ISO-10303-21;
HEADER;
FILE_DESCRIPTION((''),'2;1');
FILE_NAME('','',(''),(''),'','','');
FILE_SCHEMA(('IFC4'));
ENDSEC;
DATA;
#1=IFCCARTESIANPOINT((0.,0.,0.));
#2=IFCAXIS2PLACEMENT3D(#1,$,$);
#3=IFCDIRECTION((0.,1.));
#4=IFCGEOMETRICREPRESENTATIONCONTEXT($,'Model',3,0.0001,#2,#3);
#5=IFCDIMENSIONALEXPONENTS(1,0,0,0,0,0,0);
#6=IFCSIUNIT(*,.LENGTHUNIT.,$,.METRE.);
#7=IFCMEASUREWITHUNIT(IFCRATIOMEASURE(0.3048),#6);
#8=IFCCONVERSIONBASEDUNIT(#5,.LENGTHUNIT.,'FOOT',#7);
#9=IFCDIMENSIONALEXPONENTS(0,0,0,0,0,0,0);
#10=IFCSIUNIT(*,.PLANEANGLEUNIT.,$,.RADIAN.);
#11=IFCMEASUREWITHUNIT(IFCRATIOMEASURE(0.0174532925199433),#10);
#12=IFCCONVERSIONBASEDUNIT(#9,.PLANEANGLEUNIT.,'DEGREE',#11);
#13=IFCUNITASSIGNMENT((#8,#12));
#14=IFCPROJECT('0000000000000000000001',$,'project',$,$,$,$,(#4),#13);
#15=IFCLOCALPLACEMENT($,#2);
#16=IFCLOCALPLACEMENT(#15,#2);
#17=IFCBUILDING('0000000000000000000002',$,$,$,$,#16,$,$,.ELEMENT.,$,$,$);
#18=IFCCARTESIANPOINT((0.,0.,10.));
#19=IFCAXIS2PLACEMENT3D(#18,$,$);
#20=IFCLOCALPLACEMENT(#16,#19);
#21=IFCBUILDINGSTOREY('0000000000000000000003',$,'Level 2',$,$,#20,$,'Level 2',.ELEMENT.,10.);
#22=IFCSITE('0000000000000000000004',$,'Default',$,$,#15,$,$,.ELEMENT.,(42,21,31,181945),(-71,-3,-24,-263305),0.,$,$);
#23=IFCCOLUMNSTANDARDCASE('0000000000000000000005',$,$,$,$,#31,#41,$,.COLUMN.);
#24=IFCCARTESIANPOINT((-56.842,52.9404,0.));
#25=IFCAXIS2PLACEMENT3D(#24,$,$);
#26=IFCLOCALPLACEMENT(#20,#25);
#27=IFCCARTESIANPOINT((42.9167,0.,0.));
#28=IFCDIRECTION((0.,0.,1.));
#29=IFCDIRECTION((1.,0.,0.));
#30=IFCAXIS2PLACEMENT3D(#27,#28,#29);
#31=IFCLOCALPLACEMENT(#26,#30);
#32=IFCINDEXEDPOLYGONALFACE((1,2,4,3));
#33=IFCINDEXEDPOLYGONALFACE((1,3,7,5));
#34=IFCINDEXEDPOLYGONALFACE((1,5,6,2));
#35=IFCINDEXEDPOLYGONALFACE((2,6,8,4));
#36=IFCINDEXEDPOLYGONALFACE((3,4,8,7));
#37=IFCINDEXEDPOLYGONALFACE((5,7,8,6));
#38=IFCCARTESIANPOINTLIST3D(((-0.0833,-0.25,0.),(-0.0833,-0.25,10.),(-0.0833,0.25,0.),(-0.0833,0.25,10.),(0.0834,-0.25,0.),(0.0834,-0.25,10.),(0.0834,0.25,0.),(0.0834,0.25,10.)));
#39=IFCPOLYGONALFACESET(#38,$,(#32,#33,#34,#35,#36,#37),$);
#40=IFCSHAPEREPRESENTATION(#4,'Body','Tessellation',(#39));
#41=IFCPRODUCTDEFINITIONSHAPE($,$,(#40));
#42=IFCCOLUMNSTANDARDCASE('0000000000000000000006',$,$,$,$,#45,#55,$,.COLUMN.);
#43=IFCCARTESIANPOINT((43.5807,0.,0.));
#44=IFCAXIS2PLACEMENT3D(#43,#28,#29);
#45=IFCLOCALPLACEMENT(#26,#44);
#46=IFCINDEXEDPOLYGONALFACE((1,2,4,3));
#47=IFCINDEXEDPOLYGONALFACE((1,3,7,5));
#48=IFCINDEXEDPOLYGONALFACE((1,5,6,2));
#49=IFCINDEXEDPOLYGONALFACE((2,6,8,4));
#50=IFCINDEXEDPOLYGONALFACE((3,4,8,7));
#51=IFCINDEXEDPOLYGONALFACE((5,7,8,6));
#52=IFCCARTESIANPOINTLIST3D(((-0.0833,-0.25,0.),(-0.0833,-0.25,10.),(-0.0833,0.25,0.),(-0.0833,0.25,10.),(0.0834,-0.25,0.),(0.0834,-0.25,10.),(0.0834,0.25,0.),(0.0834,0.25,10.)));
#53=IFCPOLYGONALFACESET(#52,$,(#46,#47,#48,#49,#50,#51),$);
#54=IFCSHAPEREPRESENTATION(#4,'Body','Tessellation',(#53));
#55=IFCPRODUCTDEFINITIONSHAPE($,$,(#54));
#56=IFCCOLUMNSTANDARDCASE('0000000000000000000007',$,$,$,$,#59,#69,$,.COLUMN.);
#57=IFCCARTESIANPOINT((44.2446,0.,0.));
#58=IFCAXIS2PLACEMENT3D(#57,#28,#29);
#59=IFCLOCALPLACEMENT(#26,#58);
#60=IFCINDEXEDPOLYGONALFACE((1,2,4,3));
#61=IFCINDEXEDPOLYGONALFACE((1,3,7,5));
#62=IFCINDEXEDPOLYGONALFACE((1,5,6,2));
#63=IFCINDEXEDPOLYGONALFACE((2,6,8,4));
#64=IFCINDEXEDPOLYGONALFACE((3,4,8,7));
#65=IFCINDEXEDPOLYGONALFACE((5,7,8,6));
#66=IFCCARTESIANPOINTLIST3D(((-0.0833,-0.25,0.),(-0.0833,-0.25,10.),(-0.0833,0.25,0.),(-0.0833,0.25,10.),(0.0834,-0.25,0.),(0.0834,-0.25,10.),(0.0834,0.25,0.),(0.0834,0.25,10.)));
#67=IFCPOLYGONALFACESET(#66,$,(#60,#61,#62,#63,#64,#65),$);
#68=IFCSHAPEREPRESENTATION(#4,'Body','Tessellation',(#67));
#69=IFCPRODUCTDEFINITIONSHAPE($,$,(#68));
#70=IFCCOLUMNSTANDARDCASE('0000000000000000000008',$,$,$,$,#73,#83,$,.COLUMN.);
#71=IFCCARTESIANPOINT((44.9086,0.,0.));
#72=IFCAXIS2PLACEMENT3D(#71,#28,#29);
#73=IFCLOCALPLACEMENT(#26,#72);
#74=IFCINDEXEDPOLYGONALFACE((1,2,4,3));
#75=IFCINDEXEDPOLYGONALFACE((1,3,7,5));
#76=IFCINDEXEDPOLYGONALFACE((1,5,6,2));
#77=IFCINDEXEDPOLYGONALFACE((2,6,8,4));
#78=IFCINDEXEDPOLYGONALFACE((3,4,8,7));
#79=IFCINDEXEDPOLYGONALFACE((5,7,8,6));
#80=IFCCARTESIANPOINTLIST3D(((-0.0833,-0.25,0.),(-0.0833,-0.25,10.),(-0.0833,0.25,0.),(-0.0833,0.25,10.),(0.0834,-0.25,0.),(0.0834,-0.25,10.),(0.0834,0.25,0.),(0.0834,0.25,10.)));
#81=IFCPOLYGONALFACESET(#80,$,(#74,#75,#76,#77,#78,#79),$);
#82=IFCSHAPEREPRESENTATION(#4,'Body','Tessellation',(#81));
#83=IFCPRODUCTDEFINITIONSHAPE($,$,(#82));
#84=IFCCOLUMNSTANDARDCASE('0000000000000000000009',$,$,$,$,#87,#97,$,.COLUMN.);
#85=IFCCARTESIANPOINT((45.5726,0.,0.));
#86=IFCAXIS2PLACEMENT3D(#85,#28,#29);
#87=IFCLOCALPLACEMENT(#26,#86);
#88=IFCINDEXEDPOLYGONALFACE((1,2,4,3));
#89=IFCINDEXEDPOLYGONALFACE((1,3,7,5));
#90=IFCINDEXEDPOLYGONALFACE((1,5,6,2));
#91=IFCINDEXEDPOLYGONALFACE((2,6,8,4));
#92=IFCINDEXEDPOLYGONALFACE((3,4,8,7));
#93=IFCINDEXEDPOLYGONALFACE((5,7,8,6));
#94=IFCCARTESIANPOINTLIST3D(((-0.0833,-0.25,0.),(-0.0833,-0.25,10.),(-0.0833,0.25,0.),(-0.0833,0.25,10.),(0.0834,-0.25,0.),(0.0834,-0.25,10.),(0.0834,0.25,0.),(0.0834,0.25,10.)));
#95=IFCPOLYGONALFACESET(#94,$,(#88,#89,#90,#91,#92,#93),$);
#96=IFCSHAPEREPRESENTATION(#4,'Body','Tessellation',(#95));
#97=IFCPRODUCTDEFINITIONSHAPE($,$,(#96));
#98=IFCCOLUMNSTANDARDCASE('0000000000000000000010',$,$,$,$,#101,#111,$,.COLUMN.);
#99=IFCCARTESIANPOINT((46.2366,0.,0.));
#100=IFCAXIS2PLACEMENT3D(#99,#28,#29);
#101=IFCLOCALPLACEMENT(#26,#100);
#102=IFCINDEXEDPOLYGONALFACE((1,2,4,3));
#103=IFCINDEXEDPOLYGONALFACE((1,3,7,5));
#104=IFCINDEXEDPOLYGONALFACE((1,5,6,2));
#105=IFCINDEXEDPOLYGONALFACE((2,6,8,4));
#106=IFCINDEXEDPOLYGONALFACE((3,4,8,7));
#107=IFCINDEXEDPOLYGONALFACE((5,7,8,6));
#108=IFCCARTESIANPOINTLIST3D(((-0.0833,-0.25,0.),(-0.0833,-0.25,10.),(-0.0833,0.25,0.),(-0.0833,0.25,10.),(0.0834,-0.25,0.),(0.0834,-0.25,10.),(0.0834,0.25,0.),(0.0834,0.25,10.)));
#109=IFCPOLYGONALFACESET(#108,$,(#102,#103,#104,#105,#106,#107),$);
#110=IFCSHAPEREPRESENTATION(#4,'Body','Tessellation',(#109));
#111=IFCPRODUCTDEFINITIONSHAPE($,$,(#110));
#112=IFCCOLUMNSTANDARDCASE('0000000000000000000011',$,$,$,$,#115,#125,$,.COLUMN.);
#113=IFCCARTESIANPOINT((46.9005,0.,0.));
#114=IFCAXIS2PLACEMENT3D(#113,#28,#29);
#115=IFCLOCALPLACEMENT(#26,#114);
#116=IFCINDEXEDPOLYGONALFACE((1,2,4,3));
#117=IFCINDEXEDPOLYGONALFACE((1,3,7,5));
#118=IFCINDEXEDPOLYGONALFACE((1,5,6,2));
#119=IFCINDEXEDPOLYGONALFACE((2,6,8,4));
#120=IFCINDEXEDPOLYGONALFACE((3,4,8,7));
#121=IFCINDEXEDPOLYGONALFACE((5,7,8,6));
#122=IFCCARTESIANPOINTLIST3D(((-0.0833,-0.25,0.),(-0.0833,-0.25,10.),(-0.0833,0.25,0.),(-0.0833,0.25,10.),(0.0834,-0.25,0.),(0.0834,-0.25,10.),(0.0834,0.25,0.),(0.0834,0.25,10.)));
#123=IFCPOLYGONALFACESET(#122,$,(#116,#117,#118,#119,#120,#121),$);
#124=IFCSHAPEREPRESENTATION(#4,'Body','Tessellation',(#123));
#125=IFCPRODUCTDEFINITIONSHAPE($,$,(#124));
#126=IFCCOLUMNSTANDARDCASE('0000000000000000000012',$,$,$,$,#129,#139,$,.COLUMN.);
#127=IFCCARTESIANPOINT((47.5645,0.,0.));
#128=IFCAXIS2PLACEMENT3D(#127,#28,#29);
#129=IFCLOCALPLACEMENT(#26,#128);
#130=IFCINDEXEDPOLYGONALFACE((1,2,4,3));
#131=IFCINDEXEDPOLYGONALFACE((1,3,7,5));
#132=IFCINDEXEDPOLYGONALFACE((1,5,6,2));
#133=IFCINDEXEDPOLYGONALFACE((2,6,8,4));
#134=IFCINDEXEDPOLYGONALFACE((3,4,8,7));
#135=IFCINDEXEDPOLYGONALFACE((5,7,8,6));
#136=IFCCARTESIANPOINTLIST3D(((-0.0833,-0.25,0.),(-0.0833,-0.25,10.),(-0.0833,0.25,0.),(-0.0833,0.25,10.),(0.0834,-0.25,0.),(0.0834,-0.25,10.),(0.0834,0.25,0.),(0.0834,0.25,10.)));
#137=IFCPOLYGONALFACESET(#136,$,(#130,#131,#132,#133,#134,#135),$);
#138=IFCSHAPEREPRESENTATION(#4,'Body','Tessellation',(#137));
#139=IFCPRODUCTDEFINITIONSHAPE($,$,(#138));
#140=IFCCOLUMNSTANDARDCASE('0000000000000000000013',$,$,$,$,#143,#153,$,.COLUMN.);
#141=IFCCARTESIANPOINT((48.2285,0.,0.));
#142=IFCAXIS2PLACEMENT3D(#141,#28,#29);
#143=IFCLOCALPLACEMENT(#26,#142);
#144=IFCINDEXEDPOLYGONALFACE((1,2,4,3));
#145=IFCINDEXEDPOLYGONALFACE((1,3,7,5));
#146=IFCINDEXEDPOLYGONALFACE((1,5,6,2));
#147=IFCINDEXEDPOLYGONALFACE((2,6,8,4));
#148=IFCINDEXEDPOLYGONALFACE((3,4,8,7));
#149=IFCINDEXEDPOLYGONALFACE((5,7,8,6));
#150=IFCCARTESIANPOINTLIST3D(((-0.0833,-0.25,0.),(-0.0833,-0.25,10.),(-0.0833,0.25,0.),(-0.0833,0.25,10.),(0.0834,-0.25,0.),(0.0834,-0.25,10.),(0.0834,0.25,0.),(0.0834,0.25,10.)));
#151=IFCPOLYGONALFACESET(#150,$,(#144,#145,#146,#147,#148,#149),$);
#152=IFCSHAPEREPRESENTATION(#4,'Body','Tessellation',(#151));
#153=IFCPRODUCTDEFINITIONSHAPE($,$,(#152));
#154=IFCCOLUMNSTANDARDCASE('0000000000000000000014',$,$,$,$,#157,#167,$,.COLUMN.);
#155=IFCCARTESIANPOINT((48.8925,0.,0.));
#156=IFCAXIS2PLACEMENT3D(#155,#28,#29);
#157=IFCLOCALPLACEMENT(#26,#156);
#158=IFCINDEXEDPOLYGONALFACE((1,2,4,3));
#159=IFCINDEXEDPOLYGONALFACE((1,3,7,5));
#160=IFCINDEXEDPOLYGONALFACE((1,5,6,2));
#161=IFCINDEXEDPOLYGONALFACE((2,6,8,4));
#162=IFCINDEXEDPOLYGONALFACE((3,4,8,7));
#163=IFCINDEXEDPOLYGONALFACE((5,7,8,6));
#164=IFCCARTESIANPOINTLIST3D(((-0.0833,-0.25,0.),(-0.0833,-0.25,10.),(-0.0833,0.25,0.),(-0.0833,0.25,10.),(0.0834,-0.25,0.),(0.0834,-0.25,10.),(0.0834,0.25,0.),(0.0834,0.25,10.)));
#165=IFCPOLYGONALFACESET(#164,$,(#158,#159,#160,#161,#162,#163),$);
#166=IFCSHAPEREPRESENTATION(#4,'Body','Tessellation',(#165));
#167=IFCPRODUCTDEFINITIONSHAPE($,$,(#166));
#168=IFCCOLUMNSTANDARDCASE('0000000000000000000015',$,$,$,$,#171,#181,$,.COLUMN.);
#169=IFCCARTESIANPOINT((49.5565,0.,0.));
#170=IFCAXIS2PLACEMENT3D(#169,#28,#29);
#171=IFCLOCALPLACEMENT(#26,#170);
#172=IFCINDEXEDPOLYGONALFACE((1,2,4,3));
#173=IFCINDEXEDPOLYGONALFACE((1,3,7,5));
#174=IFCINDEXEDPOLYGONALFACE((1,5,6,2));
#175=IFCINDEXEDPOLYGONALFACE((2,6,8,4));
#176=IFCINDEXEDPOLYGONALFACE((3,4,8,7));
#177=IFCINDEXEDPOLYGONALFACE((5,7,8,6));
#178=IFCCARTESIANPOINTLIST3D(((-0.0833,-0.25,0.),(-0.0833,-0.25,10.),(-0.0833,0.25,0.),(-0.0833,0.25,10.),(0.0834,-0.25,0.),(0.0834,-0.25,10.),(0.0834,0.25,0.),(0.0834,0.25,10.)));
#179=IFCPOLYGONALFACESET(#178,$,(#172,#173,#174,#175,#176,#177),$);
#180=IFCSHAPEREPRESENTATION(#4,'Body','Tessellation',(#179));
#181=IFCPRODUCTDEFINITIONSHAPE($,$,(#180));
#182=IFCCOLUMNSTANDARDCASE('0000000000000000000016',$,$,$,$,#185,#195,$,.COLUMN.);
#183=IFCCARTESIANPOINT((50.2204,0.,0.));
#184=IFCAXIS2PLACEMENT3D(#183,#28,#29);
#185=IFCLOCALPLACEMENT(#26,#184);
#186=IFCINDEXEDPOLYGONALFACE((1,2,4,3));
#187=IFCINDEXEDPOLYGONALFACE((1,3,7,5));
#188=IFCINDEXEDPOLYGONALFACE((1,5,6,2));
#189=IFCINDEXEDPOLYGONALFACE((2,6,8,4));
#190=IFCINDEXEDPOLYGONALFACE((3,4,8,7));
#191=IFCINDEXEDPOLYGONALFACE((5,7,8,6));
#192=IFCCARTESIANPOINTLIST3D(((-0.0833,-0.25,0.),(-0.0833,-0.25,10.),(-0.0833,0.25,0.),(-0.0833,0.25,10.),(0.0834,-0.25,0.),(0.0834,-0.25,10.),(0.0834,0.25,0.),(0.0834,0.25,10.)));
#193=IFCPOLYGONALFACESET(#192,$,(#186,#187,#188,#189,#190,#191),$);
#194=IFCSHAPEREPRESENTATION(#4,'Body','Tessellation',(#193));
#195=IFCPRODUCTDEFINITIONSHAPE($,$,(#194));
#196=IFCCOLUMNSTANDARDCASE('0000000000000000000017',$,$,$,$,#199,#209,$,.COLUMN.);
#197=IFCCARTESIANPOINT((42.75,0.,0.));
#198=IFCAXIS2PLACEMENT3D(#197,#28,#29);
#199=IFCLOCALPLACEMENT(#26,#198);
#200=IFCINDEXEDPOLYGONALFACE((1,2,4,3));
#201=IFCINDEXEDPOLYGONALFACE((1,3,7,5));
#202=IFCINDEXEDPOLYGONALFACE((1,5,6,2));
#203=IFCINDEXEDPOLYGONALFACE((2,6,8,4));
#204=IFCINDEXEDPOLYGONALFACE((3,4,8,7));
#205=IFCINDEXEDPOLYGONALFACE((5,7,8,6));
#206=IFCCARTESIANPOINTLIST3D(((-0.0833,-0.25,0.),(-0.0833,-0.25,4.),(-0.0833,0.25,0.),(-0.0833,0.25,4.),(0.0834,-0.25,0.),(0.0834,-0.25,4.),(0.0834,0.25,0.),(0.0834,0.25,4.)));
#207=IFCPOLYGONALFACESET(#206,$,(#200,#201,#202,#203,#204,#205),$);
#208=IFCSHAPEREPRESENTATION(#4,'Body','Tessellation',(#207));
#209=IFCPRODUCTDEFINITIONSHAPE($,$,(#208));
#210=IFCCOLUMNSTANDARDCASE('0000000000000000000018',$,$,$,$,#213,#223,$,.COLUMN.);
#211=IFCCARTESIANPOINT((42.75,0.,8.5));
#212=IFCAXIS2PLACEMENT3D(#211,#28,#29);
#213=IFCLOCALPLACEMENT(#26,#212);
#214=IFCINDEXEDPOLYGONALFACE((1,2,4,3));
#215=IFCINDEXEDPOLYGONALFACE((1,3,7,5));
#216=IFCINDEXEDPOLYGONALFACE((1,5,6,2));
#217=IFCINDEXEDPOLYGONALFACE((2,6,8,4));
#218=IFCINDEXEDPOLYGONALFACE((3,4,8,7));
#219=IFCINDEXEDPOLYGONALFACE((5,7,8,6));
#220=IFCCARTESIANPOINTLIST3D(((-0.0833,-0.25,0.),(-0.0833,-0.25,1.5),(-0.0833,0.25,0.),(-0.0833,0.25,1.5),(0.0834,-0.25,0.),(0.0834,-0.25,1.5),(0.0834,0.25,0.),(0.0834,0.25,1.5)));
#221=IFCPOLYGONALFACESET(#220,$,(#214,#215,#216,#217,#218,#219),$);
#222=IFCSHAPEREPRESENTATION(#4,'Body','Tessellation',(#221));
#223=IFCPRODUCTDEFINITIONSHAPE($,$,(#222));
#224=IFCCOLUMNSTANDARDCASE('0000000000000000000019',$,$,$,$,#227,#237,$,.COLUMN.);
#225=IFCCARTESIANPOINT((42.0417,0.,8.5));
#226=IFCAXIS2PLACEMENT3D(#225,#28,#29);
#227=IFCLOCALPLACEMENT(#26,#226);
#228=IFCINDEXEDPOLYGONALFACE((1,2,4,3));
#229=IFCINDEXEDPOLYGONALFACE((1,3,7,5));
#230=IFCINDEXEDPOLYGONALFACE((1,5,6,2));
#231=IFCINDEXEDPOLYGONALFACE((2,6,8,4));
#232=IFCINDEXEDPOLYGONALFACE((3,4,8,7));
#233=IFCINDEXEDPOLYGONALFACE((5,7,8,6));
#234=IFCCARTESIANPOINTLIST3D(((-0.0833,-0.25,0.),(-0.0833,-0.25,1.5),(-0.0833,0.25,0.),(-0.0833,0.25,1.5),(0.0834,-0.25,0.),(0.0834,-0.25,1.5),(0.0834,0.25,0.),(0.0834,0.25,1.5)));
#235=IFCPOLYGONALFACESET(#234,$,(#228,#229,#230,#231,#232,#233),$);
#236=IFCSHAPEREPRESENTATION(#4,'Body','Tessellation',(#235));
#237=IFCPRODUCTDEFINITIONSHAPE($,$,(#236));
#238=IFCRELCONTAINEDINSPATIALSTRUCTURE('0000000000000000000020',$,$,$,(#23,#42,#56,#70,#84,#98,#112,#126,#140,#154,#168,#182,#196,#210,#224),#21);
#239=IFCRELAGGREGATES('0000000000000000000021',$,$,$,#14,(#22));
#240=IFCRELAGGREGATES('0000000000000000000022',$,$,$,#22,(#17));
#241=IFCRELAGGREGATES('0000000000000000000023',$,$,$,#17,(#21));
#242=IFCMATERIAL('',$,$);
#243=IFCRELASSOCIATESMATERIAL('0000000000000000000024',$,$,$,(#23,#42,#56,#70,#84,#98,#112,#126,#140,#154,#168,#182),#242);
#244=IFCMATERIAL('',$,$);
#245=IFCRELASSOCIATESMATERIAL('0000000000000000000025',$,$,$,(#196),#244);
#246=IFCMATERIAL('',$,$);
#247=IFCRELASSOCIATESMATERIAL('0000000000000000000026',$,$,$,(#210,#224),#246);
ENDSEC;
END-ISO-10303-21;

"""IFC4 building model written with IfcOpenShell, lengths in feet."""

from ifc_helpers import new_model, entity, si_unit, converted_unit, direction, frame, origin, place, context, project, spatial, rectangle, extrude, material, element, save


model = new_model("IFC4")

# Units and contexts
model_context = context("Model", 3, precision=0.0001, world=origin(), true_north=direction((0.0, 1.0)))
ifc_project = project(units=[converted_unit("LENGTHUNIT", "FOOT", entity("IfcRatioMeasure", 0.3048), si_unit("LENGTHUNIT", "METRE"), dimensions=[1, 0, 0, 0, 0, 0, 0]), converted_unit("PLANEANGLEUNIT", "DEGREE", entity("IfcRatioMeasure", 0.0174532925199433), si_unit("PLANEANGLEUNIT", "RADIAN"), dimensions=[0, 0, 0, 0, 0, 0, 0])], contexts=[model_context])

# Site, building, storey
site_placement = place(None, origin())
site = spatial("IfcSite", under=ifc_project, at=site_placement, Name="Default", CompositionType="ELEMENT", RefLatitude=(42, 21, 31, 181945), RefLongitude=(-71, -3, -24, -263305), RefElevation=0.0)
building_placement = place(site_placement, origin())
building = spatial("IfcBuilding", under=site, at=building_placement, CompositionType="ELEMENT")
storey_placement = place(building_placement, frame((0.0, 0.0, 10.0)))
storey = spatial("IfcBuildingStorey", under=building, at=storey_placement, Name="Level 2", LongName="Level 2", CompositionType="ELEMENT", Elevation=10.0)

# Columns
ifc_material_1 = material(Name="")
placement = place(storey_placement, frame((-56.842, 52.9404, 0.0)))
for number, where, z_axis, x_axis in (
    (1, (42.9167, 0.0, 0.0), (0.0, 0.0, 1.0), (1.0, 0.0, 0.0)),
    (2, (43.5807, 0.0, 0.0), (0.0, 0.0, 1.0), (1.0, 0.0, 0.0)),
    (3, (44.2446, 0.0, 0.0), (0.0, 0.0, 1.0), (1.0, 0.0, 0.0)),
    (4, (44.9086, 0.0, 0.0), (0.0, 0.0, 1.0), (1.0, 0.0, 0.0)),
    (5, (45.5726, 0.0, 0.0), (0.0, 0.0, 1.0), (1.0, 0.0, 0.0)),
    (6, (46.2366, 0.0, 0.0), (0.0, 0.0, 1.0), (1.0, 0.0, 0.0)),
    (7, (46.9005, 0.0, 0.0), (0.0, 0.0, 1.0), (1.0, 0.0, 0.0)),
    (8, (47.5645, 0.0, 0.0), (0.0, 0.0, 1.0), (1.0, 0.0, 0.0)),
    (9, (48.2285, 0.0, 0.0), (0.0, 0.0, 1.0), (1.0, 0.0, 0.0)),
    (10, (48.8925, 0.0, 0.0), (0.0, 0.0, 1.0), (1.0, 0.0, 0.0)),
    (11, (49.5565, 0.0, 0.0), (0.0, 0.0, 1.0), (1.0, 0.0, 0.0)),
    (12, (50.2204, 0.0, 0.0), (0.0, 0.0, 1.0), (1.0, 0.0, 0.0)),
):
    element("IfcColumnStandardCase", number, at=place(placement, frame(where, z_axis=z_axis, x_axis=x_axis)), inside=storey, material=ifc_material_1, PredefinedType="COLUMN", context=model_context, shape_type="SweptSolid", body=[
        extrude(rectangle(XDim=0.1667, YDim=0.5), origin(), (0.0, 0.0, 1.0), 10.0),
    ])
ifc_material_2 = material(Name="")
for number, where, z_axis, x_axis in (
    (13, (42.75, 0.0, 0.0), (0.0, 0.0, 1.0), (1.0, 0.0, 0.0)),
):
    element("IfcColumnStandardCase", number, at=place(placement, frame(where, z_axis=z_axis, x_axis=x_axis)), inside=storey, material=ifc_material_2, PredefinedType="COLUMN", context=model_context, shape_type="SweptSolid", body=[
        extrude(rectangle(XDim=0.1667, YDim=0.5), origin(), (0.0, 0.0, 1.0), 4.0),
    ])
ifc_material_3 = material(Name="")
for number, where, z_axis, x_axis in (
    (14, (42.75, 0.0, 8.5), (0.0, 0.0, 1.0), (1.0, 0.0, 0.0)),
    (15, (42.0417, 0.0, 8.5), (0.0, 0.0, 1.0), (1.0, 0.0, 0.0)),
):
    element("IfcColumnStandardCase", number, at=place(placement, frame(where, z_axis=z_axis, x_axis=x_axis)), inside=storey, material=ifc_material_3, PredefinedType="COLUMN", context=model_context, shape_type="SweptSolid", body=[
        extrude(rectangle(XDim=0.1667, YDim=0.5), origin(), (0.0, 0.0, 1.0), 1.5),
    ])

save(model, "model.ifc")
